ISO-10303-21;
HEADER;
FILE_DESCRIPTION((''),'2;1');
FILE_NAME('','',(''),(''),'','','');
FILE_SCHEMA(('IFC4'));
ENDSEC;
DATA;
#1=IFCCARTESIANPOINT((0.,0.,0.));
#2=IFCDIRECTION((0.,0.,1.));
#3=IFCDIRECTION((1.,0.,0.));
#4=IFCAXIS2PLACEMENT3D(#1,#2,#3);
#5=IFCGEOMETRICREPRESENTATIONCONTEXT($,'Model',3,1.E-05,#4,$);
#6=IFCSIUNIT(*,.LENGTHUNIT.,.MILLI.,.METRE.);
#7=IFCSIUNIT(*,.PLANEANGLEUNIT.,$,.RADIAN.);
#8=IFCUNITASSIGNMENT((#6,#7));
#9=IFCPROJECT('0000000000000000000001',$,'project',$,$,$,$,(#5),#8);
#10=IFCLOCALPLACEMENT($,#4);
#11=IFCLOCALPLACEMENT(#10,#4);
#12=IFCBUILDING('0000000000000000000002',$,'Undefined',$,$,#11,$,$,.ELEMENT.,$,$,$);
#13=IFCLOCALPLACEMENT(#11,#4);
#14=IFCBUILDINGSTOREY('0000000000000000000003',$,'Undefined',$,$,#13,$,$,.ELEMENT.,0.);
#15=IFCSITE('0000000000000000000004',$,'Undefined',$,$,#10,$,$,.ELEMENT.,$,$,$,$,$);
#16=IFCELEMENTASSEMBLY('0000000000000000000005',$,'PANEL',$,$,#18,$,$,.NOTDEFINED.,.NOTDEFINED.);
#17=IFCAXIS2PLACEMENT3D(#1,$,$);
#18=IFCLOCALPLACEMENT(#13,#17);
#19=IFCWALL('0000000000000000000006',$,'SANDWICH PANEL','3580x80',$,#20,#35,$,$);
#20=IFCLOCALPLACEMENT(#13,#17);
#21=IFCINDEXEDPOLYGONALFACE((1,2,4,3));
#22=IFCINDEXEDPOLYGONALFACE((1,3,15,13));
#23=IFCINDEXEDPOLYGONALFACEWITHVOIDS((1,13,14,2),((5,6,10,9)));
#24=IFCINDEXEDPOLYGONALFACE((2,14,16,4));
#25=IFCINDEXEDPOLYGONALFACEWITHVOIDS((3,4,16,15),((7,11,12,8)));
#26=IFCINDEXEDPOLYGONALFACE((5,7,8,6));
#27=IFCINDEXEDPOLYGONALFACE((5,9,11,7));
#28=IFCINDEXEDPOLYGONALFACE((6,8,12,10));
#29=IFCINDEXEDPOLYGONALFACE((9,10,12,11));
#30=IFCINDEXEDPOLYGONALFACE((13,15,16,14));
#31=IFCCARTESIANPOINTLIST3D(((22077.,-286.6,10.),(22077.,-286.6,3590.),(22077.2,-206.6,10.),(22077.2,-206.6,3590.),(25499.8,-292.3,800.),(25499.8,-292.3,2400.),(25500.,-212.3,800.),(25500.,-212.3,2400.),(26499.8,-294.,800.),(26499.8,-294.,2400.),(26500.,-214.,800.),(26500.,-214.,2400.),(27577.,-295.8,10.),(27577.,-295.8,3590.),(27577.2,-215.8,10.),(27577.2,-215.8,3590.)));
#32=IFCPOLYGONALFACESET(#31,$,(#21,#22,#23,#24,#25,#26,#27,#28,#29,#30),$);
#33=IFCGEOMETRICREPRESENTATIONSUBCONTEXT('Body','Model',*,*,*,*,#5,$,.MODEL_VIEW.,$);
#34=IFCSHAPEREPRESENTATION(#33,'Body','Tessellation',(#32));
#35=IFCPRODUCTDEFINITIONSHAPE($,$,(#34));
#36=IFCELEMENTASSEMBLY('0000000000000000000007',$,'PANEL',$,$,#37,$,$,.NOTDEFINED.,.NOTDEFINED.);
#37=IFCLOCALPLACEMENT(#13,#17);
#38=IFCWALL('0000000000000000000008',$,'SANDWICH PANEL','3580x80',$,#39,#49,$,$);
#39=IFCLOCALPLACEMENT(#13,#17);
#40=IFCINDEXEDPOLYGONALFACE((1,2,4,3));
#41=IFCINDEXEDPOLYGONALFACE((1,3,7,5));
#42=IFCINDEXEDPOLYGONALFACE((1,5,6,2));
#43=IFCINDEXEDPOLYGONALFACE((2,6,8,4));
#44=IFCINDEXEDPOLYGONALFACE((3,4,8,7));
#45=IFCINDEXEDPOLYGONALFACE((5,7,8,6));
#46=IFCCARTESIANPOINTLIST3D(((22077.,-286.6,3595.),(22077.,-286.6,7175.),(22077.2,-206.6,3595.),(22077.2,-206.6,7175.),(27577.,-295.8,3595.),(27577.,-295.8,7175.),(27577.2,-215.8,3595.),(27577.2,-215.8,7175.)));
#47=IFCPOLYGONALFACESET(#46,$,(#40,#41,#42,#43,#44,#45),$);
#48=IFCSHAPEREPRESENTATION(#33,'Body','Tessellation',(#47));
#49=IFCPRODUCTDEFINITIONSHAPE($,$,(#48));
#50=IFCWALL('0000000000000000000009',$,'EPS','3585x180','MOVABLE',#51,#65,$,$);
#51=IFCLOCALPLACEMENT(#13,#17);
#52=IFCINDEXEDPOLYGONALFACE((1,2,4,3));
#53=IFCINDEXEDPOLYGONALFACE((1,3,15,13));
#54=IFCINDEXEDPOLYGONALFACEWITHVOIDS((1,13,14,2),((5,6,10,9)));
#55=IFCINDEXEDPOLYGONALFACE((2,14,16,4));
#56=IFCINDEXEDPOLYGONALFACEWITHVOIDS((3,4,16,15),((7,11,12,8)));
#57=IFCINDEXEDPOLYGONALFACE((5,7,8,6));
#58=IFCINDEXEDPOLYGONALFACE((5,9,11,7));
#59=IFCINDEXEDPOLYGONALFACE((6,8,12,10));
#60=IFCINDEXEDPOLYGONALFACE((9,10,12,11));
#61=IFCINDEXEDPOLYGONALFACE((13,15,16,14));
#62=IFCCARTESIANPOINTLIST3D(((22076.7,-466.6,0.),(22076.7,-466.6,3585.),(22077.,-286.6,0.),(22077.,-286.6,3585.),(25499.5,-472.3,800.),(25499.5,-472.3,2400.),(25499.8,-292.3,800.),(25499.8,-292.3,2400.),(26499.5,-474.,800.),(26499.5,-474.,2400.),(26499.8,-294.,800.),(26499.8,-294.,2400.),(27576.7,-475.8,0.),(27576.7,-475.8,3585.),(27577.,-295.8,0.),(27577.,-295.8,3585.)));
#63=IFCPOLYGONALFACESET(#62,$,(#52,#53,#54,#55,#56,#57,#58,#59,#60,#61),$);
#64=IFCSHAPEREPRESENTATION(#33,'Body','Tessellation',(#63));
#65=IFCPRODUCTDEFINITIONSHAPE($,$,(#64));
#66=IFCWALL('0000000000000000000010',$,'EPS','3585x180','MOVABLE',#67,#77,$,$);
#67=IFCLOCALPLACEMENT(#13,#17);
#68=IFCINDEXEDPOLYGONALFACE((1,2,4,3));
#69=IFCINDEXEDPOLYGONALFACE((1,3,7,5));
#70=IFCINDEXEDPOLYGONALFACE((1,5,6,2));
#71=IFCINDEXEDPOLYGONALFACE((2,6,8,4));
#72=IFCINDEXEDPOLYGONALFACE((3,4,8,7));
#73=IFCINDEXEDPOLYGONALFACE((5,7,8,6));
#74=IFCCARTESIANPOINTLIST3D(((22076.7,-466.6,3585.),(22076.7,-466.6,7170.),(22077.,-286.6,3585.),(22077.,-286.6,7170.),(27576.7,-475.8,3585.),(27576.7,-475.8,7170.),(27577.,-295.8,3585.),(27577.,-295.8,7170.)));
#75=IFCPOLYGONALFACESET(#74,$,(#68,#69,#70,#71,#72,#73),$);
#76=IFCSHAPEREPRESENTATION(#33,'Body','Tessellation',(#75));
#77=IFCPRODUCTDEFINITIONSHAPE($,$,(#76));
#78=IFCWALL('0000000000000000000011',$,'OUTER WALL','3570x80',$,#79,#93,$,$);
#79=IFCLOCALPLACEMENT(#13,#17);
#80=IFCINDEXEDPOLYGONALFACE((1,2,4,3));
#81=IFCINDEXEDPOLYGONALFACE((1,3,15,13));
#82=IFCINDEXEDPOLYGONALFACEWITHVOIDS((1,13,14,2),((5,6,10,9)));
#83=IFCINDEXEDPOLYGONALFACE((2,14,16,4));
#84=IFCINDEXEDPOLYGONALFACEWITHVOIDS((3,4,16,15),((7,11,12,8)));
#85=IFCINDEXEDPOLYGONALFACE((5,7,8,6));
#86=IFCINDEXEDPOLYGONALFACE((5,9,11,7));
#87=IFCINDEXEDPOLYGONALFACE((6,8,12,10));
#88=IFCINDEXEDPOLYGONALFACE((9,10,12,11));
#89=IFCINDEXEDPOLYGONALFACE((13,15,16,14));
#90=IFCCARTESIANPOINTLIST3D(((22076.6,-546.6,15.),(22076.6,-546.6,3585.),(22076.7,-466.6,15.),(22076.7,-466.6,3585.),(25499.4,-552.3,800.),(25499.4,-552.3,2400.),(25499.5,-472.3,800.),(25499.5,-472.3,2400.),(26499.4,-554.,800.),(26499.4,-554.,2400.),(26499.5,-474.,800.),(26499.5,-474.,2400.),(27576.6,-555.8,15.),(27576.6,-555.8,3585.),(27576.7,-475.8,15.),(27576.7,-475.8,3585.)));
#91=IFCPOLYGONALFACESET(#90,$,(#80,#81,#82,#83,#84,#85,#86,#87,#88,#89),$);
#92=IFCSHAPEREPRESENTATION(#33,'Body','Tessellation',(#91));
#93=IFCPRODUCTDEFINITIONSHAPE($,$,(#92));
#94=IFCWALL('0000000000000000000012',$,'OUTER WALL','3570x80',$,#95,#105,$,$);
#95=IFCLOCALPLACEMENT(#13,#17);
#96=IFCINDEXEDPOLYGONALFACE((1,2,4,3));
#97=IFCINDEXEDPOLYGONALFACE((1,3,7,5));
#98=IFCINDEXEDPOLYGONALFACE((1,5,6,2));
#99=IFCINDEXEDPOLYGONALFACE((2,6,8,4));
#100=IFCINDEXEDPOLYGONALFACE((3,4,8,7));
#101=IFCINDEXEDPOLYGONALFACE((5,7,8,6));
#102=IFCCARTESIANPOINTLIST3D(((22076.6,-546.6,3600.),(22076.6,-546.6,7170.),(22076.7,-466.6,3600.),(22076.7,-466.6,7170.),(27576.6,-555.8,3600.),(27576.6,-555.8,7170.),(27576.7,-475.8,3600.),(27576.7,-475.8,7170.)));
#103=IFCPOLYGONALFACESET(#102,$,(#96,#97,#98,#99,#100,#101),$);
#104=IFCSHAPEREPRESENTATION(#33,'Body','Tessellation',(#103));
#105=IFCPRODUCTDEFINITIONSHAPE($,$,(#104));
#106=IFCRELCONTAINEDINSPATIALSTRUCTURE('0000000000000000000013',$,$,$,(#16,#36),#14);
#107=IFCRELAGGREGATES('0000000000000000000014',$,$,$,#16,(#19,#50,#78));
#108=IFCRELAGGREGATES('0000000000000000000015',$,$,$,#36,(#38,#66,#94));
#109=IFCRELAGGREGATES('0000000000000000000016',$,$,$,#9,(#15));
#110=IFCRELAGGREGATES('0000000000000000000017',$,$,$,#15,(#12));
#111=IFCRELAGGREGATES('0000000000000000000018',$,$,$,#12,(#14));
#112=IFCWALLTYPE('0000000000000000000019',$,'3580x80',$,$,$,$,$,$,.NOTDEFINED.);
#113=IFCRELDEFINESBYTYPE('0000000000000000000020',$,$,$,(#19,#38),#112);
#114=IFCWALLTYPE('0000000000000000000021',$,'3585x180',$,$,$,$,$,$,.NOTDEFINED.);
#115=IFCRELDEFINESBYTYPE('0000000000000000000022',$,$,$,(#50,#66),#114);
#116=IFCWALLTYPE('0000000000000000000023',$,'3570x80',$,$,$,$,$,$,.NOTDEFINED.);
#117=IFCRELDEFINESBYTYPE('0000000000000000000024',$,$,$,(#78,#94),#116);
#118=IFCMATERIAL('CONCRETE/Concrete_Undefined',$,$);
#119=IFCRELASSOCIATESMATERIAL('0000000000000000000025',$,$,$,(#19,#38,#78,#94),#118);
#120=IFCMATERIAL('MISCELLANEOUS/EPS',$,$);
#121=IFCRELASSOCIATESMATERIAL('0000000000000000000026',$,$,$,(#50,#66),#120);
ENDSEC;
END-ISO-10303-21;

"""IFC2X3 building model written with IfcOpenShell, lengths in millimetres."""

from ifc_helpers import new_model, si_unit, frame, frame_2d, origin_with_axes, place, context, subcontext, project, spatial, polyline, rectangle, outline, extrude, material, type_object, element, aggregate, save


model = new_model("IFC2X3")

# Units and contexts
model_context = context("Model", 3, precision=1e-05, world=origin_with_axes())
body_context = subcontext(model_context, "Body", "Model", "MODEL_VIEW")
ifc_project = project(units=[si_unit("LENGTHUNIT", "METRE", prefix="MILLI"), si_unit("PLANEANGLEUNIT", "RADIAN")], contexts=[model_context])

# Site, building, storey
site_placement = place(None, origin_with_axes())
site = spatial("IfcSite", under=ifc_project, at=site_placement, Name="Undefined", CompositionType="ELEMENT")
building_placement = place(site_placement, origin_with_axes())
building = spatial("IfcBuilding", under=site, at=building_placement, Name="Undefined", CompositionType="ELEMENT")
storey_placement = place(building_placement, origin_with_axes())
storey = spatial("IfcBuildingStorey", under=building, at=storey_placement, Name="Undefined", CompositionType="ELEMENT", Elevation=0.0)

# Shared definitions
ifc_material_1 = material(Name="CONCRETE/Concrete_Undefined")

# Element assembly, wall, opening
assembly_1_placement = place(storey_placement, origin_with_axes())
assembly_1 = element("IfcElementAssembly", 1, at=assembly_1_placement, inside=storey, Name="PANEL", AssemblyPlace="NOTDEFINED", PredefinedType="NOTDEFINED")
wall_type_1 = type_object("IfcWallType", Name="3580x80", PredefinedType="NOTDEFINED")
wall_1_placement = place(assembly_1_placement, frame((22077.1, -246.6, 10.0), z_axis=(0.0, 0.0, 1.0), x_axis=(0.999999, -0.001684, 0.0)))
wall_1 = element("IfcWall", 2, at=wall_1_placement, type_object=wall_type_1, material=ifc_material_1, Name="SANDWICH PANEL", Description="3580x80", context=body_context, shape_type="SweptSolid", body=[
    extrude(rectangle(XDim=5500.0, YDim=80.0, at=frame_2d((0.0, 2750.0), x_axis=(0.0, -1.0))), frame((0.0, 0.0, 0.0), z_axis=(0.0, 0.0, 1.0), x_axis=(0.0, -1.0, 0.0)), (0.0, 0.0, 1.0), 3580.0),
])
opening_1_placement = place(assembly_1_placement, frame((22077.1, -246.6, 10.0), z_axis=(0.0, 0.0, 1.0), x_axis=(0.999999, -0.001684, 0.0)))
element("IfcOpeningElement", 3, at=opening_1_placement, cuts=wall_1, ObjectType="Recess", context=body_context, shape_type="SweptSolid", body=[
    extrude(outline(polyline([(0.0, 0.0), (1000.0, 0.0), (1000.0, 1600.0), (0.0, 1600.0), (0.0, 0.0)])), frame((3422.8, 90.0, 790.0), z_axis=(0.0, -1.0, 0.0), x_axis=(1.0, 0.0, 0.0)), (0.0, 0.0, 1.0), 180.0),
])

# Element assembly, wall
assembly_2_placement = place(storey_placement, origin_with_axes())
assembly_2 = element("IfcElementAssembly", 4, at=assembly_2_placement, inside=storey, Name="PANEL", AssemblyPlace="NOTDEFINED", PredefinedType="NOTDEFINED")
wall_2_placement = place(assembly_2_placement, frame((22077.1, -246.6, 3595.0), z_axis=(0.0, 0.0, 1.0), x_axis=(0.999999, -0.001684, 0.0)))
wall_2 = element("IfcWall", 5, at=wall_2_placement, type_object=wall_type_1, material=ifc_material_1, Name="SANDWICH PANEL", Description="3580x80", context=body_context, shape_type="SweptSolid", body=[
    extrude(rectangle(XDim=5500.0, YDim=80.0, at=frame_2d((0.0, 2750.0), x_axis=(0.0, -1.0))), frame((0.0, 0.0, 0.0), z_axis=(0.0, 0.0, 1.0), x_axis=(0.0, -1.0, 0.0)), (0.0, 0.0, 1.0), 3580.0),
])

# Wall, opening
ifc_material_2 = material(Name="MISCELLANEOUS/EPS")
wall_type_2 = type_object("IfcWallType", Name="3585x180", PredefinedType="NOTDEFINED")
wall_3_placement = place(assembly_1_placement, frame((22076.9, -376.6, 0.0), z_axis=(0.0, 0.0, 1.0), x_axis=(0.999999, -0.001684, 0.0)))
wall_3 = element("IfcWall", 6, at=wall_3_placement, type_object=wall_type_2, material=ifc_material_2, Name="EPS", Description="3585x180", ObjectType="MOVABLE", context=body_context, shape_type="SweptSolid", body=[
    extrude(rectangle(XDim=5500.0, YDim=180.0, at=frame_2d((0.0, 2750.0), x_axis=(0.0, -1.0))), frame((0.0, 0.0, 0.0), z_axis=(0.0, 0.0, 1.0), x_axis=(0.0, -1.0, 0.0)), (0.0, 0.0, 1.0), 3585.0),
])
opening_2_placement = place(assembly_1_placement, frame((22076.9, -376.6, 0.0), z_axis=(0.0, 0.0, 1.0), x_axis=(0.999999, -0.001684, 0.0)))
element("IfcOpeningElement", 7, at=opening_2_placement, cuts=wall_3, ObjectType="Recess", context=body_context, shape_type="SweptSolid", body=[
    extrude(outline(polyline([(0.0, 0.0), (1000.0, 0.0), (1000.0, 1600.0), (0.0, 1600.0), (0.0, 0.0)])), frame((3422.8, 140.0, 800.0), z_axis=(0.0, -1.0, 0.0), x_axis=(1.0, 0.0, 0.0)), (0.0, 0.0, 1.0), 280.0),
])

# Wall
wall_4_placement = place(assembly_2_placement, frame((22076.9, -376.6, 3585.0), z_axis=(0.0, 0.0, 1.0), x_axis=(0.999999, -0.001684, 0.0)))
wall_4 = element("IfcWall", 8, at=wall_4_placement, type_object=wall_type_2, material=ifc_material_2, Name="EPS", Description="3585x180", ObjectType="MOVABLE", context=body_context, shape_type="SweptSolid", body=[
    extrude(rectangle(XDim=5500.0, YDim=180.0, at=frame_2d((0.0, 2750.0), x_axis=(0.0, -1.0))), frame((0.0, 0.0, 0.0), z_axis=(0.0, 0.0, 1.0), x_axis=(0.0, -1.0, 0.0)), (0.0, 0.0, 1.0), 3585.0),
])

# Wall, opening
wall_type_3 = type_object("IfcWallType", Name="3570x80", PredefinedType="NOTDEFINED")
wall_5_placement = place(assembly_1_placement, frame((22076.7, -506.6, 15.0), z_axis=(0.0, 0.0, 1.0), x_axis=(0.999999, -0.001684, 0.0)))
wall_5 = element("IfcWall", 9, at=wall_5_placement, type_object=wall_type_3, material=ifc_material_1, Name="OUTER WALL", Description="3570x80", context=body_context, shape_type="SweptSolid", body=[
    extrude(rectangle(XDim=5500.0, YDim=80.0, at=frame_2d((0.0, 2750.0), x_axis=(0.0, -1.0))), frame((0.0, 0.0, 0.0), z_axis=(0.0, 0.0, 1.0), x_axis=(0.0, -1.0, 0.0)), (0.0, 0.0, 1.0), 3570.0),
])
opening_3_placement = place(assembly_1_placement, frame((22076.7, -506.6, 15.0), z_axis=(0.0, 0.0, 1.0), x_axis=(0.999999, -0.001684, 0.0)))
element("IfcOpeningElement", 10, at=opening_3_placement, cuts=wall_5, ObjectType="Recess", context=body_context, shape_type="SweptSolid", body=[
    extrude(outline(polyline([(0.0, 0.0), (1000.0, 0.0), (1000.0, 1600.0), (0.0, 1600.0), (0.0, 0.0)])), frame((3422.8, 90.0, 785.0), z_axis=(0.0, -1.0, 0.0), x_axis=(1.0, 0.0, 0.0)), (0.0, 0.0, 1.0), 180.0),
])
aggregate(assembly_1, [wall_1, wall_3, wall_5])

# Wall
wall_6_placement = place(assembly_2_placement, frame((22076.7, -506.6, 3600.0), z_axis=(0.0, 0.0, 1.0), x_axis=(0.999999, -0.001684, 0.0)))
wall_6 = element("IfcWall", 11, at=wall_6_placement, type_object=wall_type_3, material=ifc_material_1, Name="OUTER WALL", Description="3570x80", context=body_context, shape_type="SweptSolid", body=[
    extrude(rectangle(XDim=5500.0, YDim=80.0, at=frame_2d((0.0, 2750.0), x_axis=(0.0, -1.0))), frame((0.0, 0.0, 0.0), z_axis=(0.0, 0.0, 1.0), x_axis=(0.0, -1.0, 0.0)), (0.0, 0.0, 1.0), 3570.0),
])
aggregate(assembly_2, [wall_2, wall_4, wall_6])

save(model, "model.ifc")
